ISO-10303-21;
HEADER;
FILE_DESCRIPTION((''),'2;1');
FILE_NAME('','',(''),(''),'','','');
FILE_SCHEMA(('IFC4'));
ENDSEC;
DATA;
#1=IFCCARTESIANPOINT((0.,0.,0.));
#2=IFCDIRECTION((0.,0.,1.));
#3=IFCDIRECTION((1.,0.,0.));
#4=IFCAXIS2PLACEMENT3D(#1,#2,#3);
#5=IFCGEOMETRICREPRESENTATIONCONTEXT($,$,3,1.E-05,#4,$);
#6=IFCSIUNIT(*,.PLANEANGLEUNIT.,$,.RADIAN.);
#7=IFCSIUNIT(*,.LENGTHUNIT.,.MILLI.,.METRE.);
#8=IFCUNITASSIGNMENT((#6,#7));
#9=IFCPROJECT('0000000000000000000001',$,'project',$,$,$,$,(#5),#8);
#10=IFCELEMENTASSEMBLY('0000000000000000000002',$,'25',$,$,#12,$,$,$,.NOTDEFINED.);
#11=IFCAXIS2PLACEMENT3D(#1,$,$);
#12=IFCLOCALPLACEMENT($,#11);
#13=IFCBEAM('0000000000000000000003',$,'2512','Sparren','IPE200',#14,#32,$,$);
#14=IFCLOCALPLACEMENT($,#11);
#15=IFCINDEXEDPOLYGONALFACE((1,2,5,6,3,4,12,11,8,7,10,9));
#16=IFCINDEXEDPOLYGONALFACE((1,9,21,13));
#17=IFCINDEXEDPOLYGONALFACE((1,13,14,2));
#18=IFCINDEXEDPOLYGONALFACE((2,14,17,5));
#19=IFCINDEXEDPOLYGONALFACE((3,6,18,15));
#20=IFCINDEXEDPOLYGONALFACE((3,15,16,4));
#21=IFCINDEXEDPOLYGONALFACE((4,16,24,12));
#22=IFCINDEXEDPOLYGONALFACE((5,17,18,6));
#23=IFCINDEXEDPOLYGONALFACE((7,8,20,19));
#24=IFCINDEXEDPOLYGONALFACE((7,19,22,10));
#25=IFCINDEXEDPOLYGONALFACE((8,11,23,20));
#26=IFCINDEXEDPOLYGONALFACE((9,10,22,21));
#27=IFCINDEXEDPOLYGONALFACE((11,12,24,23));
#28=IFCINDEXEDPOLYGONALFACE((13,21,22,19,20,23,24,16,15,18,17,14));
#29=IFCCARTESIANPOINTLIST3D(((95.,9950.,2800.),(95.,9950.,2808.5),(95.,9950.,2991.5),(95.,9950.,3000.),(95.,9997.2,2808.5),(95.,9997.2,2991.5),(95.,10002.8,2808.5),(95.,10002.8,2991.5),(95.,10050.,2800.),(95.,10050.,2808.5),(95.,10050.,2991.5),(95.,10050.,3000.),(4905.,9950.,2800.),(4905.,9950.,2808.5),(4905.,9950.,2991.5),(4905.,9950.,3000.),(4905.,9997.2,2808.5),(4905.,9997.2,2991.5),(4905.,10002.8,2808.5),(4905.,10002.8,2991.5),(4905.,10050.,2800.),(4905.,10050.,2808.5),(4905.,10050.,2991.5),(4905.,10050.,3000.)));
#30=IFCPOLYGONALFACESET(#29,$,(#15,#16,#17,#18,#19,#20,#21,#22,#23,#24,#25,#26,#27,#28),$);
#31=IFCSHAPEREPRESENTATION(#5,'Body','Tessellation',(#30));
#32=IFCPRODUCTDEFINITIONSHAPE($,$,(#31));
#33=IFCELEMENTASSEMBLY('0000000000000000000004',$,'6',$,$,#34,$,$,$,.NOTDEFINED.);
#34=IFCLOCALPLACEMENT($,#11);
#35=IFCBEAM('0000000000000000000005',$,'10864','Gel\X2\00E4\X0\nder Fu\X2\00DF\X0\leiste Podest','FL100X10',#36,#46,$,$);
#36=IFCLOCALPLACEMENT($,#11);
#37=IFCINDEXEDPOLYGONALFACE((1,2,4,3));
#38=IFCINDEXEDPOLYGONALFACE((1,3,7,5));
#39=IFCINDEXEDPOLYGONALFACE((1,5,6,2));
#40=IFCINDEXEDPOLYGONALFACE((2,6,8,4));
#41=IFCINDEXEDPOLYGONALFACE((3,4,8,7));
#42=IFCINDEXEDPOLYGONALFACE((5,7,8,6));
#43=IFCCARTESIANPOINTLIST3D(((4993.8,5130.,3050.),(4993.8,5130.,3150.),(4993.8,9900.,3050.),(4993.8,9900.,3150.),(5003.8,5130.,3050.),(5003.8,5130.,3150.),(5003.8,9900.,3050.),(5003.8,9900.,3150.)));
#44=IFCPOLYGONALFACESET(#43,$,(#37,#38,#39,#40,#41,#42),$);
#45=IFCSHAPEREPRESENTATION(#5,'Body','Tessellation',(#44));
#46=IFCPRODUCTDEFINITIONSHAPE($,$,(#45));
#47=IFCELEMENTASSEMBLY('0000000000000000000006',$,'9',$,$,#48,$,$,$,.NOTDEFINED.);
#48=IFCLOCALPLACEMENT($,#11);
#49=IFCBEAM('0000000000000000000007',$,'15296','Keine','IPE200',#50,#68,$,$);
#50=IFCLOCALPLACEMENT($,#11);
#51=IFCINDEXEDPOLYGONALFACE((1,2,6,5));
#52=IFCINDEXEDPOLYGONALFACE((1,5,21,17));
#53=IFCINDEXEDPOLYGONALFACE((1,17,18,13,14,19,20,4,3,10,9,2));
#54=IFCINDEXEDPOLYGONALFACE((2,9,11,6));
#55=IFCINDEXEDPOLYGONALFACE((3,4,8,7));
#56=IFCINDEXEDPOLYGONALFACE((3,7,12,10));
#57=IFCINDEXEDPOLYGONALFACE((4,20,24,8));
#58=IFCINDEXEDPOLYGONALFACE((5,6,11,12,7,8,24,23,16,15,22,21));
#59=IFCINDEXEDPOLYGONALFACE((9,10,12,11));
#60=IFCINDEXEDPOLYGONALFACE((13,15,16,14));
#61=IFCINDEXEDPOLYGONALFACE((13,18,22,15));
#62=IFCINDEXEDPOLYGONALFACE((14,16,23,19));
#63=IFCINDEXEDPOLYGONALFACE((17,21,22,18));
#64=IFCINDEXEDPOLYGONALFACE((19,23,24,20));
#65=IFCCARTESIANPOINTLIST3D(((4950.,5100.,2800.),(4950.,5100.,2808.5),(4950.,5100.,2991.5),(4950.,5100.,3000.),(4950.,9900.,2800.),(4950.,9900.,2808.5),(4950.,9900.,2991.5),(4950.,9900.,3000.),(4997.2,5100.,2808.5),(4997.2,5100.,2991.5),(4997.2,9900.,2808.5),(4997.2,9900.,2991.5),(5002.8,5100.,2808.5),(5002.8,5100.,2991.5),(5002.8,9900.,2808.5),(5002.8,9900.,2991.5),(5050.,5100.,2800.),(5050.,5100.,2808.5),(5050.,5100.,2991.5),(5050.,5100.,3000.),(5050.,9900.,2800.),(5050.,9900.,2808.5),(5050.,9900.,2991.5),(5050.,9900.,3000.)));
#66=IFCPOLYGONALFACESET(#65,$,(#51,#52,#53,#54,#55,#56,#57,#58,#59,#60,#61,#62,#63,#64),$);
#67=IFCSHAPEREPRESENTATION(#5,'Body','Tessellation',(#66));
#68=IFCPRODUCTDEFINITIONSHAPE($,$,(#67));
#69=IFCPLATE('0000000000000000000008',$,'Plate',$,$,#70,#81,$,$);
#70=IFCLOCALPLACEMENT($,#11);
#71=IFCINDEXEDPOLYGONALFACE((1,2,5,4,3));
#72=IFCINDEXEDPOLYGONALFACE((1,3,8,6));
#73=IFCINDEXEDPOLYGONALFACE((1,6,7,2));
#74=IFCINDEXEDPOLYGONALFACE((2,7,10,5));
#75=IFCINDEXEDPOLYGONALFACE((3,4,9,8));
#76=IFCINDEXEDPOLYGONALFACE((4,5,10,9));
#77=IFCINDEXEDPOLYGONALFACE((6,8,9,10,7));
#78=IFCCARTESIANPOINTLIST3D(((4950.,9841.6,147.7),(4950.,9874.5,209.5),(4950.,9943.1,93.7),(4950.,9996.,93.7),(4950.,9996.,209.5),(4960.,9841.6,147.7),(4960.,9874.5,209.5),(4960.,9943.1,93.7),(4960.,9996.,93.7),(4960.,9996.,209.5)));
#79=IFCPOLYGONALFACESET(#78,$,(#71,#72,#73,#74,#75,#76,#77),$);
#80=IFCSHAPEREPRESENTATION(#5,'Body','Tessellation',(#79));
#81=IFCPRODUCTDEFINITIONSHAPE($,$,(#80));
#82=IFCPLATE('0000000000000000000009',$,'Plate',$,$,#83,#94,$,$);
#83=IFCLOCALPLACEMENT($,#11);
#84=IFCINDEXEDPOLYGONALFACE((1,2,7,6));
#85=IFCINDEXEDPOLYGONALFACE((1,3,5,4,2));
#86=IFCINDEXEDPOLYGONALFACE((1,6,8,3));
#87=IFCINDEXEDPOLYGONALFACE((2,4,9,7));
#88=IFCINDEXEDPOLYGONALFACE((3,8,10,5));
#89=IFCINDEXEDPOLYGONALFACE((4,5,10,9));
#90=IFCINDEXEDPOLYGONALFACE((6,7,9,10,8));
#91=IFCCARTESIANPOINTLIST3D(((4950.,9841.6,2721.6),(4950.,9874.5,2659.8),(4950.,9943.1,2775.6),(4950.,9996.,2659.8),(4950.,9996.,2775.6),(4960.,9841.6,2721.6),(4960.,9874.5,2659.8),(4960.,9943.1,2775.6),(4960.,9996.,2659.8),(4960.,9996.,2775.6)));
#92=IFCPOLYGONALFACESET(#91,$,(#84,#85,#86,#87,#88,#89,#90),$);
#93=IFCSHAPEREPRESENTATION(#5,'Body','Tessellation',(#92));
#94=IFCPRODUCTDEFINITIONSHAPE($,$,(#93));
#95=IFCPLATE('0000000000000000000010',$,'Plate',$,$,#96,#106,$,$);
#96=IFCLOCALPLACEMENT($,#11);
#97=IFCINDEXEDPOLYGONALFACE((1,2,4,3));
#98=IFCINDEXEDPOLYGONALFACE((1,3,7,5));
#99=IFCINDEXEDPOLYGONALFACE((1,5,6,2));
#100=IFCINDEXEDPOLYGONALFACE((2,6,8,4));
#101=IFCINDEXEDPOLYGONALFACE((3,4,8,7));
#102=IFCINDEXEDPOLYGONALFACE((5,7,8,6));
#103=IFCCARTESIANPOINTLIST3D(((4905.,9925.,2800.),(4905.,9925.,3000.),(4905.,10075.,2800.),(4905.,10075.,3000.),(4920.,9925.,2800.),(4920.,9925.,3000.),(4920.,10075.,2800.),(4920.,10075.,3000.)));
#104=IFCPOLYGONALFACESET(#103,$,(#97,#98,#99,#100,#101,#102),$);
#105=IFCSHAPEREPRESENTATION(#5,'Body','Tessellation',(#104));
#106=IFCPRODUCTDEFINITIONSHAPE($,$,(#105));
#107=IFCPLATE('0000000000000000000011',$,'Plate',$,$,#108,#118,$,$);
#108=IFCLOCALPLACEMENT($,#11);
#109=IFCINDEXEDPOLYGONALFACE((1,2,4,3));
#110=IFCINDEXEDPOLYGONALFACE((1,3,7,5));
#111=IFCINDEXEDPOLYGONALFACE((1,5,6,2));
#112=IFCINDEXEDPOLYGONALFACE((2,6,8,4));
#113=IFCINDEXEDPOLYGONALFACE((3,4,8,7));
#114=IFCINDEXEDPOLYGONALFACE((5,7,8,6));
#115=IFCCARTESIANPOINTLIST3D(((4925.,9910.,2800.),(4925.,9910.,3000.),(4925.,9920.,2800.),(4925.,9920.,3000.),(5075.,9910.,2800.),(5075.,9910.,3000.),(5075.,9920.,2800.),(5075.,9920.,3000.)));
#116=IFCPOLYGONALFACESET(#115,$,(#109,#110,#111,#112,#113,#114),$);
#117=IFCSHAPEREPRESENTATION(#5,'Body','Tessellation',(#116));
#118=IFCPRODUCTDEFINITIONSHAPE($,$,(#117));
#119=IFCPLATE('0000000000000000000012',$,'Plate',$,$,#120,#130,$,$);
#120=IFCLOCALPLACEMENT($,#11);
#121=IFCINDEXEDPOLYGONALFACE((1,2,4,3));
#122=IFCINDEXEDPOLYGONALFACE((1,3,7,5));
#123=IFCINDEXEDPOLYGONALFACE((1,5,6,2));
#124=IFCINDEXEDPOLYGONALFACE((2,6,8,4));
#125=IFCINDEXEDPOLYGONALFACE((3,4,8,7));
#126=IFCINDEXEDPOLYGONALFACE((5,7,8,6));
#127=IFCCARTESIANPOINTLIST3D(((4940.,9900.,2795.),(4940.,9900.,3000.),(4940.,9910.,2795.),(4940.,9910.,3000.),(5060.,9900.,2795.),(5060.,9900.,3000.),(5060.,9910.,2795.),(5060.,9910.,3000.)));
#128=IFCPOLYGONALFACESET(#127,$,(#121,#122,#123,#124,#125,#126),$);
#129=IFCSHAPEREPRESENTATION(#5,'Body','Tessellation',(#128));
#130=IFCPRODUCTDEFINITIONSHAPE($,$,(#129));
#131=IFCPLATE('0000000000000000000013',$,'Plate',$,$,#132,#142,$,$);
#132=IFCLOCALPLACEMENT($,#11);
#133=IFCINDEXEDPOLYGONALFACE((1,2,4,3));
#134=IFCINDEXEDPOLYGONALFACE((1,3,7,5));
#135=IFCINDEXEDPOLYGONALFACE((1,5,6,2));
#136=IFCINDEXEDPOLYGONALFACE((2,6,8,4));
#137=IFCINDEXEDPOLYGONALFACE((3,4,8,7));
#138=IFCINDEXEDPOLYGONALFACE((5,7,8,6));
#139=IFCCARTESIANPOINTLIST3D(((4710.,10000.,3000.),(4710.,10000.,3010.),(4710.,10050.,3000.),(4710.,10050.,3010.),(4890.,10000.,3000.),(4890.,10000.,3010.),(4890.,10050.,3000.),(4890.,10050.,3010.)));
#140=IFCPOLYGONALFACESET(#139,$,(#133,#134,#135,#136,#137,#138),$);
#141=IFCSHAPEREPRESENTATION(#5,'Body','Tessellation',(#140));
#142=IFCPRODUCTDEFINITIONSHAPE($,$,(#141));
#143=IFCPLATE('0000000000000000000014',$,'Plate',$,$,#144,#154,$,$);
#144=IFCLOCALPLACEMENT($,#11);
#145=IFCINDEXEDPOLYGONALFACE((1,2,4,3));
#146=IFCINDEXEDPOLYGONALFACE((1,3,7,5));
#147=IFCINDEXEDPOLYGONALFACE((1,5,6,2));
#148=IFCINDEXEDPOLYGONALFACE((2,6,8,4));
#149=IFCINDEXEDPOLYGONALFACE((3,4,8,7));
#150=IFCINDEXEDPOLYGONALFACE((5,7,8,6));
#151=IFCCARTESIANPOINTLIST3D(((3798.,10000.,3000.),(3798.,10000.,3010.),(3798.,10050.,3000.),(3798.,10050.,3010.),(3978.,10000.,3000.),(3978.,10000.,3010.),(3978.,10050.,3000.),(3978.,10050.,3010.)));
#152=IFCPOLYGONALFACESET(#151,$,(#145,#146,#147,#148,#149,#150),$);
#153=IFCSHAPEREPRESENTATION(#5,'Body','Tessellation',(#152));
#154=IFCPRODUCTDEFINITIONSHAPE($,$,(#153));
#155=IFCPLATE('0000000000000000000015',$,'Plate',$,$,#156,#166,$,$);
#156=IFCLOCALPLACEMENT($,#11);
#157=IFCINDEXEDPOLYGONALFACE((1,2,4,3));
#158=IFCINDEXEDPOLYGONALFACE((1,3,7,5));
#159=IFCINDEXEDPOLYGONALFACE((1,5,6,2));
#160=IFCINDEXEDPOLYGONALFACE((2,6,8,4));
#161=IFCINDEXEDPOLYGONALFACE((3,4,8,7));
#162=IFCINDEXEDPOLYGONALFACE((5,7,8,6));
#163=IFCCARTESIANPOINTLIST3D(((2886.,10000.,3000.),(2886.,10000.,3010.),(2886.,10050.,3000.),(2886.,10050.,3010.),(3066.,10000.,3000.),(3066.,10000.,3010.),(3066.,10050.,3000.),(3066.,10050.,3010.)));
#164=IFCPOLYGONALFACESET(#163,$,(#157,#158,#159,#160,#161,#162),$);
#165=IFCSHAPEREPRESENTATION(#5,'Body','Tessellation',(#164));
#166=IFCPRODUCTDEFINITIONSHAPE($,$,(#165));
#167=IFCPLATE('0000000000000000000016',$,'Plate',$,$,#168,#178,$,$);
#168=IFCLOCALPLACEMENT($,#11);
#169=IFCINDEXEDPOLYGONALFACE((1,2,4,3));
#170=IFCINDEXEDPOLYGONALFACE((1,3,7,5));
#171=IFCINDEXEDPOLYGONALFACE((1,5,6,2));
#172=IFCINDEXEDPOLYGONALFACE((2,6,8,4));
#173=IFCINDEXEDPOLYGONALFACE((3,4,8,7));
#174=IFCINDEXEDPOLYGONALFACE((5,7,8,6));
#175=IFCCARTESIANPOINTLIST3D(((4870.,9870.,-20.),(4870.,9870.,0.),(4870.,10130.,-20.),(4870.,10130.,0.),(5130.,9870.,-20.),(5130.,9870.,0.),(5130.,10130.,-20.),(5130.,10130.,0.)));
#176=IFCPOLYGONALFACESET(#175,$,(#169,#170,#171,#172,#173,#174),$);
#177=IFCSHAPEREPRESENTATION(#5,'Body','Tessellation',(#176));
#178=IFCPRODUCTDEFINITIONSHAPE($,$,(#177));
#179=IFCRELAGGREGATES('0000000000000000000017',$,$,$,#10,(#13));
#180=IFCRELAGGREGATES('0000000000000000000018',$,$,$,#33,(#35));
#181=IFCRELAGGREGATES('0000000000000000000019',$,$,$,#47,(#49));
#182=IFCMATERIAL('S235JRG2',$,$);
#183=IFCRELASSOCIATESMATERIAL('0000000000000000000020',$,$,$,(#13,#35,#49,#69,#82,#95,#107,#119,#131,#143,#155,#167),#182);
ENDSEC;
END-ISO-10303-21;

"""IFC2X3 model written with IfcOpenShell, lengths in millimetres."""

from ifc_helpers import new_model, si_unit, frame, origin_with_axes, place, context, project, polyline, outline, extrude, clip, halfspace, material, element, aggregate, save


model = new_model("IFC2X3")

# Units and contexts
context_of_model = context(None, 3, precision=1e-05, world=origin_with_axes())
ifc_project = project(units=[si_unit("PLANEANGLEUNIT", "RADIAN"), si_unit("LENGTHUNIT", "METRE", prefix="MILLI")], contexts=[context_of_model])

# Element assembly, beam
assembly_1_placement = place(None, frame((5000.0, 10000.0, 6000.0), z_axis=(0.0, 0.0, 1.0), x_axis=(-1.0, 0.0, 0.0)))
assembly_1 = element("IfcElementAssembly", 1, at=assembly_1_placement, Name="25", PredefinedType="NOTDEFINED")
ifc_material = material(Name="S235JRG2")
placement_1 = place(None, frame((5000.0, 10000.0, 2900.0), z_axis=(0.0, 0.0, 1.0), x_axis=(-1.0, 0.0, 0.0)))
beam_1_placement = place(placement_1, origin_with_axes())
beam_1 = element("IfcBeam", 2, at=beam_1_placement, material=ifc_material, Name="2512", Description="Sparren", ObjectType="IPE200", context=context_of_model, shape_type="Clipping", body=[
    clip(clip(extrude(outline(polyline([(50.0, -100.0), (50.0, -91.5), (2.8, -91.5), (2.8, 91.5), (50.0, 91.5), (50.0, 100.0), (-50.0, 100.0), (-50.0, 91.5), (-2.8, 91.5), (-2.8, -91.5), (-50.0, -91.5), (-50.0, -100.0), (50.0, -100.0), (50.0, -100.0)])), frame((0.0, 0.0, 0.0), z_axis=(1.0, 0.0, 0.0), x_axis=(0.0, 1.0, 0.0)), (0.0, 0.0, 1.0), 5000.0), halfspace(frame((95.0, 0.0, 100.0), z_axis=(-1.0, 0.0, 0.0), x_axis=(0.0, 0.0, -1.0)), False)), halfspace(frame((4905.0, 0.0, 100.0), z_axis=(1.0, 0.0, 0.0), x_axis=(0.0, 0.0, 1.0)), False)),
])
aggregate(assembly_1, [beam_1])

# Element assembly, beam
assembly_2_placement = place(None, frame((1.2, 5130.0, 6100.0), z_axis=(0.0, 0.0, 1.0), x_axis=(0.0, 1.0, 0.0)))
assembly_2 = element("IfcElementAssembly", 3, at=assembly_2_placement, Name="6", PredefinedType="NOTDEFINED")
placement_2 = place(None, frame((4998.8, 9900.0, 3100.0), z_axis=(0.0, 0.0, 1.0), x_axis=(0.0, -1.0, 0.0)))
beam_2_placement = place(placement_2, origin_with_axes())
beam_2 = element("IfcBeam", 4, at=beam_2_placement, material=ifc_material, Name="10864", Description="Geländer Fußleiste Podest", ObjectType="FL100X10", context=context_of_model, shape_type="SweptSolid", body=[
    extrude(outline(polyline([(5.0, -50.0), (5.0, 50.0), (-5.0, 50.0), (-5.0, -50.0), (5.0, -50.0), (5.0, -50.0)])), frame((0.0, 0.0, 0.0), z_axis=(1.0, 0.0, 0.0), x_axis=(0.0, 1.0, 0.0)), (0.0, 0.0, 1.0), 4770.0),
])
aggregate(assembly_2, [beam_2])

# Element assembly, beam
assembly_3_placement = place(None, frame((5000.0, 10000.0, 6000.0), z_axis=(0.0, 0.0, 1.0), x_axis=(0.0, -1.0, 0.0)))
assembly_3 = element("IfcElementAssembly", 5, at=assembly_3_placement, Name="9", PredefinedType="NOTDEFINED")
placement_3 = place(None, frame((5000.0, 10000.0, 2900.0), z_axis=(0.0, 0.0, 1.0), x_axis=(0.0, -1.0, 0.0)))
beam_3_placement = place(placement_3, origin_with_axes())
beam_3 = element("IfcBeam", 6, at=beam_3_placement, material=ifc_material, Name="15296", Description="Keine", ObjectType="IPE200", context=context_of_model, shape_type="Clipping", body=[
    clip(clip(extrude(outline(polyline([(50.0, -100.0), (50.0, -91.5), (2.8, -91.5), (2.8, 91.5), (50.0, 91.5), (50.0, 100.0), (-50.0, 100.0), (-50.0, 91.5), (-2.8, 91.5), (-2.8, -91.5), (-50.0, -91.5), (-50.0, -100.0), (50.0, -100.0), (50.0, -100.0)])), frame((0.0, 0.0, 0.0), z_axis=(1.0, 0.0, 0.0), x_axis=(0.0, 1.0, 0.0)), (0.0, 0.0, 1.0), 5000.0), halfspace(frame((4900.0, 0.0, 100.0), z_axis=(1.0, 0.0, 0.0), x_axis=(0.0, 0.0, 1.0)), False)), halfspace(frame((100.0, 0.0, 100.0), z_axis=(-1.0, 0.0, 0.0), x_axis=(0.0, 0.0, -1.0)), False)),
])
aggregate(assembly_3, [beam_3])

# Plates
placement_4 = place(None, origin_with_axes())
plate_1_placement = place(placement_4, frame((4950.0, 9943.1, 93.7), z_axis=(0.0, 0.0, 1.0), x_axis=(1.0, 0.0, 0.0)))
element("IfcPlate", 7, at=plate_1_placement, material=ifc_material, Name="Plate", context=context_of_model, shape_type="SweptSolid", body=[
    extrude(outline(polyline([(0.0, 0.0), (52.9, 0.0), (52.9, 115.8), (-68.6, 115.8), (-101.5, 54.1), (0.0, 0.0)])), frame((0.0, 0.0, 0.0), z_axis=(1.0, 0.0, 0.0), x_axis=(0.0, 1.0, 0.0)), (0.0, 0.0, 1.0), 10.0),
])
placement_5 = place(None, origin_with_axes())
plate_2_placement = place(placement_5, frame((4960.0, 9943.1, 2775.6), z_axis=(0.0, 0.0, -1.0), x_axis=(-1.0, 0.0, 0.0)))
element("IfcPlate", 8, at=plate_2_placement, material=ifc_material, Name="Plate", context=context_of_model, shape_type="SweptSolid", body=[
    extrude(outline(polyline([(0.0, 0.0), (52.9, 0.0), (52.9, 115.8), (-68.6, 115.8), (-101.5, 54.1), (0.0, 0.0)])), frame((0.0, 0.0, 0.0), z_axis=(1.0, 0.0, 0.0), x_axis=(0.0, 1.0, 0.0)), (0.0, 0.0, 1.0), 10.0),
])
placement_6 = place(None, origin_with_axes())
plate_3_placement = place(placement_6, frame((4905.0, 10075.0, 2800.0), z_axis=(0.0, -1.0, 0.0), x_axis=(1.0, 0.0, 0.0)))
element("IfcPlate", 9, at=plate_3_placement, material=ifc_material, Name="Plate", context=context_of_model, shape_type="SweptSolid", body=[
    extrude(outline(polyline([(0.0, 0.0), (200.0, 0.0), (200.0, 150.0), (0.0, 150.0), (0.0, 0.0)])), frame((0.0, 0.0, 0.0), z_axis=(1.0, 0.0, 0.0), x_axis=(0.0, 1.0, 0.0)), (0.0, 0.0, 1.0), 15.0),
])
placement_7 = place(None, origin_with_axes())
plate_4_placement = place(placement_7, frame((5075.0, 9920.0, 3000.0), z_axis=(0.0, 0.0, -1.0), x_axis=(0.0, -1.0, 0.0)))
element("IfcPlate", 10, at=plate_4_placement, material=ifc_material, Name="Plate", context=context_of_model, shape_type="SweptSolid", body=[
    extrude(outline(polyline([(0.0, 0.0), (150.0, 0.0), (150.0, 200.0), (0.0, 200.0), (0.0, 0.0)])), frame((0.0, 0.0, 0.0), z_axis=(1.0, 0.0, 0.0), x_axis=(0.0, 1.0, 0.0)), (0.0, 0.0, 1.0), 10.0),
])
placement_8 = place(None, origin_with_axes())
plate_5_placement = place(placement_8, frame((5060.0, 9900.0, 2795.0), z_axis=(0.0, 0.0, 1.0), x_axis=(0.0, 1.0, 0.0)))
element("IfcPlate", 11, at=plate_5_placement, material=ifc_material, Name="Plate", context=context_of_model, shape_type="SweptSolid", body=[
    extrude(outline(polyline([(0.0, 0.0), (120.0, 0.0), (120.0, 205.0), (0.0, 205.0), (0.0, 0.0)])), frame((0.0, 0.0, 0.0), z_axis=(1.0, 0.0, 0.0), x_axis=(0.0, 1.0, 0.0)), (0.0, 0.0, 1.0), 10.0),
])
placement_9 = place(None, origin_with_axes())
plate_6_placement = place(placement_9, frame((4890.0, 10000.0, 3010.0), z_axis=(0.0, 1.0, 0.0), x_axis=(0.0, 0.0, -1.0)))
element("IfcPlate", 12, at=plate_6_placement, material=ifc_material, Name="Plate", context=context_of_model, shape_type="SweptSolid", body=[
    extrude(outline(polyline([(0.0, 0.0), (180.0, 0.0), (180.0, 50.0), (0.0, 50.0), (0.0, 0.0)])), frame((0.0, 0.0, 0.0), z_axis=(1.0, 0.0, 0.0), x_axis=(0.0, 1.0, 0.0)), (0.0, 0.0, 1.0), 10.0),
])
placement_10 = place(None, origin_with_axes())
plate_7_placement = place(placement_10, frame((3978.0, 10000.0, 3010.0), z_axis=(0.0, 1.0, 0.0), x_axis=(0.0, 0.0, -1.0)))
element("IfcPlate", 13, at=plate_7_placement, material=ifc_material, Name="Plate", context=context_of_model, shape_type="SweptSolid", body=[
    extrude(outline(polyline([(0.0, 0.0), (180.0, 0.0), (180.0, 50.0), (0.0, 50.0), (0.0, 0.0)])), frame((0.0, 0.0, 0.0), z_axis=(1.0, 0.0, 0.0), x_axis=(0.0, 1.0, 0.0)), (0.0, 0.0, 1.0), 10.0),
])
placement_11 = place(None, origin_with_axes())
plate_8_placement = place(placement_11, frame((3066.0, 10000.0, 3010.0), z_axis=(0.0, 1.0, 0.0), x_axis=(0.0, 0.0, -1.0)))
element("IfcPlate", 14, at=plate_8_placement, material=ifc_material, Name="Plate", context=context_of_model, shape_type="SweptSolid", body=[
    extrude(outline(polyline([(0.0, 0.0), (180.0, 0.0), (180.0, 50.0), (0.0, 50.0), (0.0, 0.0)])), frame((0.0, 0.0, 0.0), z_axis=(1.0, 0.0, 0.0), x_axis=(0.0, 1.0, 0.0)), (0.0, 0.0, 1.0), 10.0),
])
placement_12 = place(None, origin_with_axes())
plate_9_placement = place(placement_12, frame((4870.0, 9870.0, 0.0), z_axis=(1.0, 0.0, 0.0), x_axis=(0.0, 0.0, -1.0)))
element("IfcPlate", 15, at=plate_9_placement, material=ifc_material, Name="Plate", context=context_of_model, shape_type="SweptSolid", body=[
    extrude(outline(polyline([(0.0, 0.0), (260.0, 0.0), (260.0, 260.0), (0.0, 260.0), (0.0, 0.0)])), frame((0.0, 0.0, 0.0), z_axis=(1.0, 0.0, 0.0), x_axis=(0.0, 1.0, 0.0)), (0.0, 0.0, 1.0), 20.0),
])

save(model, "model.ifc")
